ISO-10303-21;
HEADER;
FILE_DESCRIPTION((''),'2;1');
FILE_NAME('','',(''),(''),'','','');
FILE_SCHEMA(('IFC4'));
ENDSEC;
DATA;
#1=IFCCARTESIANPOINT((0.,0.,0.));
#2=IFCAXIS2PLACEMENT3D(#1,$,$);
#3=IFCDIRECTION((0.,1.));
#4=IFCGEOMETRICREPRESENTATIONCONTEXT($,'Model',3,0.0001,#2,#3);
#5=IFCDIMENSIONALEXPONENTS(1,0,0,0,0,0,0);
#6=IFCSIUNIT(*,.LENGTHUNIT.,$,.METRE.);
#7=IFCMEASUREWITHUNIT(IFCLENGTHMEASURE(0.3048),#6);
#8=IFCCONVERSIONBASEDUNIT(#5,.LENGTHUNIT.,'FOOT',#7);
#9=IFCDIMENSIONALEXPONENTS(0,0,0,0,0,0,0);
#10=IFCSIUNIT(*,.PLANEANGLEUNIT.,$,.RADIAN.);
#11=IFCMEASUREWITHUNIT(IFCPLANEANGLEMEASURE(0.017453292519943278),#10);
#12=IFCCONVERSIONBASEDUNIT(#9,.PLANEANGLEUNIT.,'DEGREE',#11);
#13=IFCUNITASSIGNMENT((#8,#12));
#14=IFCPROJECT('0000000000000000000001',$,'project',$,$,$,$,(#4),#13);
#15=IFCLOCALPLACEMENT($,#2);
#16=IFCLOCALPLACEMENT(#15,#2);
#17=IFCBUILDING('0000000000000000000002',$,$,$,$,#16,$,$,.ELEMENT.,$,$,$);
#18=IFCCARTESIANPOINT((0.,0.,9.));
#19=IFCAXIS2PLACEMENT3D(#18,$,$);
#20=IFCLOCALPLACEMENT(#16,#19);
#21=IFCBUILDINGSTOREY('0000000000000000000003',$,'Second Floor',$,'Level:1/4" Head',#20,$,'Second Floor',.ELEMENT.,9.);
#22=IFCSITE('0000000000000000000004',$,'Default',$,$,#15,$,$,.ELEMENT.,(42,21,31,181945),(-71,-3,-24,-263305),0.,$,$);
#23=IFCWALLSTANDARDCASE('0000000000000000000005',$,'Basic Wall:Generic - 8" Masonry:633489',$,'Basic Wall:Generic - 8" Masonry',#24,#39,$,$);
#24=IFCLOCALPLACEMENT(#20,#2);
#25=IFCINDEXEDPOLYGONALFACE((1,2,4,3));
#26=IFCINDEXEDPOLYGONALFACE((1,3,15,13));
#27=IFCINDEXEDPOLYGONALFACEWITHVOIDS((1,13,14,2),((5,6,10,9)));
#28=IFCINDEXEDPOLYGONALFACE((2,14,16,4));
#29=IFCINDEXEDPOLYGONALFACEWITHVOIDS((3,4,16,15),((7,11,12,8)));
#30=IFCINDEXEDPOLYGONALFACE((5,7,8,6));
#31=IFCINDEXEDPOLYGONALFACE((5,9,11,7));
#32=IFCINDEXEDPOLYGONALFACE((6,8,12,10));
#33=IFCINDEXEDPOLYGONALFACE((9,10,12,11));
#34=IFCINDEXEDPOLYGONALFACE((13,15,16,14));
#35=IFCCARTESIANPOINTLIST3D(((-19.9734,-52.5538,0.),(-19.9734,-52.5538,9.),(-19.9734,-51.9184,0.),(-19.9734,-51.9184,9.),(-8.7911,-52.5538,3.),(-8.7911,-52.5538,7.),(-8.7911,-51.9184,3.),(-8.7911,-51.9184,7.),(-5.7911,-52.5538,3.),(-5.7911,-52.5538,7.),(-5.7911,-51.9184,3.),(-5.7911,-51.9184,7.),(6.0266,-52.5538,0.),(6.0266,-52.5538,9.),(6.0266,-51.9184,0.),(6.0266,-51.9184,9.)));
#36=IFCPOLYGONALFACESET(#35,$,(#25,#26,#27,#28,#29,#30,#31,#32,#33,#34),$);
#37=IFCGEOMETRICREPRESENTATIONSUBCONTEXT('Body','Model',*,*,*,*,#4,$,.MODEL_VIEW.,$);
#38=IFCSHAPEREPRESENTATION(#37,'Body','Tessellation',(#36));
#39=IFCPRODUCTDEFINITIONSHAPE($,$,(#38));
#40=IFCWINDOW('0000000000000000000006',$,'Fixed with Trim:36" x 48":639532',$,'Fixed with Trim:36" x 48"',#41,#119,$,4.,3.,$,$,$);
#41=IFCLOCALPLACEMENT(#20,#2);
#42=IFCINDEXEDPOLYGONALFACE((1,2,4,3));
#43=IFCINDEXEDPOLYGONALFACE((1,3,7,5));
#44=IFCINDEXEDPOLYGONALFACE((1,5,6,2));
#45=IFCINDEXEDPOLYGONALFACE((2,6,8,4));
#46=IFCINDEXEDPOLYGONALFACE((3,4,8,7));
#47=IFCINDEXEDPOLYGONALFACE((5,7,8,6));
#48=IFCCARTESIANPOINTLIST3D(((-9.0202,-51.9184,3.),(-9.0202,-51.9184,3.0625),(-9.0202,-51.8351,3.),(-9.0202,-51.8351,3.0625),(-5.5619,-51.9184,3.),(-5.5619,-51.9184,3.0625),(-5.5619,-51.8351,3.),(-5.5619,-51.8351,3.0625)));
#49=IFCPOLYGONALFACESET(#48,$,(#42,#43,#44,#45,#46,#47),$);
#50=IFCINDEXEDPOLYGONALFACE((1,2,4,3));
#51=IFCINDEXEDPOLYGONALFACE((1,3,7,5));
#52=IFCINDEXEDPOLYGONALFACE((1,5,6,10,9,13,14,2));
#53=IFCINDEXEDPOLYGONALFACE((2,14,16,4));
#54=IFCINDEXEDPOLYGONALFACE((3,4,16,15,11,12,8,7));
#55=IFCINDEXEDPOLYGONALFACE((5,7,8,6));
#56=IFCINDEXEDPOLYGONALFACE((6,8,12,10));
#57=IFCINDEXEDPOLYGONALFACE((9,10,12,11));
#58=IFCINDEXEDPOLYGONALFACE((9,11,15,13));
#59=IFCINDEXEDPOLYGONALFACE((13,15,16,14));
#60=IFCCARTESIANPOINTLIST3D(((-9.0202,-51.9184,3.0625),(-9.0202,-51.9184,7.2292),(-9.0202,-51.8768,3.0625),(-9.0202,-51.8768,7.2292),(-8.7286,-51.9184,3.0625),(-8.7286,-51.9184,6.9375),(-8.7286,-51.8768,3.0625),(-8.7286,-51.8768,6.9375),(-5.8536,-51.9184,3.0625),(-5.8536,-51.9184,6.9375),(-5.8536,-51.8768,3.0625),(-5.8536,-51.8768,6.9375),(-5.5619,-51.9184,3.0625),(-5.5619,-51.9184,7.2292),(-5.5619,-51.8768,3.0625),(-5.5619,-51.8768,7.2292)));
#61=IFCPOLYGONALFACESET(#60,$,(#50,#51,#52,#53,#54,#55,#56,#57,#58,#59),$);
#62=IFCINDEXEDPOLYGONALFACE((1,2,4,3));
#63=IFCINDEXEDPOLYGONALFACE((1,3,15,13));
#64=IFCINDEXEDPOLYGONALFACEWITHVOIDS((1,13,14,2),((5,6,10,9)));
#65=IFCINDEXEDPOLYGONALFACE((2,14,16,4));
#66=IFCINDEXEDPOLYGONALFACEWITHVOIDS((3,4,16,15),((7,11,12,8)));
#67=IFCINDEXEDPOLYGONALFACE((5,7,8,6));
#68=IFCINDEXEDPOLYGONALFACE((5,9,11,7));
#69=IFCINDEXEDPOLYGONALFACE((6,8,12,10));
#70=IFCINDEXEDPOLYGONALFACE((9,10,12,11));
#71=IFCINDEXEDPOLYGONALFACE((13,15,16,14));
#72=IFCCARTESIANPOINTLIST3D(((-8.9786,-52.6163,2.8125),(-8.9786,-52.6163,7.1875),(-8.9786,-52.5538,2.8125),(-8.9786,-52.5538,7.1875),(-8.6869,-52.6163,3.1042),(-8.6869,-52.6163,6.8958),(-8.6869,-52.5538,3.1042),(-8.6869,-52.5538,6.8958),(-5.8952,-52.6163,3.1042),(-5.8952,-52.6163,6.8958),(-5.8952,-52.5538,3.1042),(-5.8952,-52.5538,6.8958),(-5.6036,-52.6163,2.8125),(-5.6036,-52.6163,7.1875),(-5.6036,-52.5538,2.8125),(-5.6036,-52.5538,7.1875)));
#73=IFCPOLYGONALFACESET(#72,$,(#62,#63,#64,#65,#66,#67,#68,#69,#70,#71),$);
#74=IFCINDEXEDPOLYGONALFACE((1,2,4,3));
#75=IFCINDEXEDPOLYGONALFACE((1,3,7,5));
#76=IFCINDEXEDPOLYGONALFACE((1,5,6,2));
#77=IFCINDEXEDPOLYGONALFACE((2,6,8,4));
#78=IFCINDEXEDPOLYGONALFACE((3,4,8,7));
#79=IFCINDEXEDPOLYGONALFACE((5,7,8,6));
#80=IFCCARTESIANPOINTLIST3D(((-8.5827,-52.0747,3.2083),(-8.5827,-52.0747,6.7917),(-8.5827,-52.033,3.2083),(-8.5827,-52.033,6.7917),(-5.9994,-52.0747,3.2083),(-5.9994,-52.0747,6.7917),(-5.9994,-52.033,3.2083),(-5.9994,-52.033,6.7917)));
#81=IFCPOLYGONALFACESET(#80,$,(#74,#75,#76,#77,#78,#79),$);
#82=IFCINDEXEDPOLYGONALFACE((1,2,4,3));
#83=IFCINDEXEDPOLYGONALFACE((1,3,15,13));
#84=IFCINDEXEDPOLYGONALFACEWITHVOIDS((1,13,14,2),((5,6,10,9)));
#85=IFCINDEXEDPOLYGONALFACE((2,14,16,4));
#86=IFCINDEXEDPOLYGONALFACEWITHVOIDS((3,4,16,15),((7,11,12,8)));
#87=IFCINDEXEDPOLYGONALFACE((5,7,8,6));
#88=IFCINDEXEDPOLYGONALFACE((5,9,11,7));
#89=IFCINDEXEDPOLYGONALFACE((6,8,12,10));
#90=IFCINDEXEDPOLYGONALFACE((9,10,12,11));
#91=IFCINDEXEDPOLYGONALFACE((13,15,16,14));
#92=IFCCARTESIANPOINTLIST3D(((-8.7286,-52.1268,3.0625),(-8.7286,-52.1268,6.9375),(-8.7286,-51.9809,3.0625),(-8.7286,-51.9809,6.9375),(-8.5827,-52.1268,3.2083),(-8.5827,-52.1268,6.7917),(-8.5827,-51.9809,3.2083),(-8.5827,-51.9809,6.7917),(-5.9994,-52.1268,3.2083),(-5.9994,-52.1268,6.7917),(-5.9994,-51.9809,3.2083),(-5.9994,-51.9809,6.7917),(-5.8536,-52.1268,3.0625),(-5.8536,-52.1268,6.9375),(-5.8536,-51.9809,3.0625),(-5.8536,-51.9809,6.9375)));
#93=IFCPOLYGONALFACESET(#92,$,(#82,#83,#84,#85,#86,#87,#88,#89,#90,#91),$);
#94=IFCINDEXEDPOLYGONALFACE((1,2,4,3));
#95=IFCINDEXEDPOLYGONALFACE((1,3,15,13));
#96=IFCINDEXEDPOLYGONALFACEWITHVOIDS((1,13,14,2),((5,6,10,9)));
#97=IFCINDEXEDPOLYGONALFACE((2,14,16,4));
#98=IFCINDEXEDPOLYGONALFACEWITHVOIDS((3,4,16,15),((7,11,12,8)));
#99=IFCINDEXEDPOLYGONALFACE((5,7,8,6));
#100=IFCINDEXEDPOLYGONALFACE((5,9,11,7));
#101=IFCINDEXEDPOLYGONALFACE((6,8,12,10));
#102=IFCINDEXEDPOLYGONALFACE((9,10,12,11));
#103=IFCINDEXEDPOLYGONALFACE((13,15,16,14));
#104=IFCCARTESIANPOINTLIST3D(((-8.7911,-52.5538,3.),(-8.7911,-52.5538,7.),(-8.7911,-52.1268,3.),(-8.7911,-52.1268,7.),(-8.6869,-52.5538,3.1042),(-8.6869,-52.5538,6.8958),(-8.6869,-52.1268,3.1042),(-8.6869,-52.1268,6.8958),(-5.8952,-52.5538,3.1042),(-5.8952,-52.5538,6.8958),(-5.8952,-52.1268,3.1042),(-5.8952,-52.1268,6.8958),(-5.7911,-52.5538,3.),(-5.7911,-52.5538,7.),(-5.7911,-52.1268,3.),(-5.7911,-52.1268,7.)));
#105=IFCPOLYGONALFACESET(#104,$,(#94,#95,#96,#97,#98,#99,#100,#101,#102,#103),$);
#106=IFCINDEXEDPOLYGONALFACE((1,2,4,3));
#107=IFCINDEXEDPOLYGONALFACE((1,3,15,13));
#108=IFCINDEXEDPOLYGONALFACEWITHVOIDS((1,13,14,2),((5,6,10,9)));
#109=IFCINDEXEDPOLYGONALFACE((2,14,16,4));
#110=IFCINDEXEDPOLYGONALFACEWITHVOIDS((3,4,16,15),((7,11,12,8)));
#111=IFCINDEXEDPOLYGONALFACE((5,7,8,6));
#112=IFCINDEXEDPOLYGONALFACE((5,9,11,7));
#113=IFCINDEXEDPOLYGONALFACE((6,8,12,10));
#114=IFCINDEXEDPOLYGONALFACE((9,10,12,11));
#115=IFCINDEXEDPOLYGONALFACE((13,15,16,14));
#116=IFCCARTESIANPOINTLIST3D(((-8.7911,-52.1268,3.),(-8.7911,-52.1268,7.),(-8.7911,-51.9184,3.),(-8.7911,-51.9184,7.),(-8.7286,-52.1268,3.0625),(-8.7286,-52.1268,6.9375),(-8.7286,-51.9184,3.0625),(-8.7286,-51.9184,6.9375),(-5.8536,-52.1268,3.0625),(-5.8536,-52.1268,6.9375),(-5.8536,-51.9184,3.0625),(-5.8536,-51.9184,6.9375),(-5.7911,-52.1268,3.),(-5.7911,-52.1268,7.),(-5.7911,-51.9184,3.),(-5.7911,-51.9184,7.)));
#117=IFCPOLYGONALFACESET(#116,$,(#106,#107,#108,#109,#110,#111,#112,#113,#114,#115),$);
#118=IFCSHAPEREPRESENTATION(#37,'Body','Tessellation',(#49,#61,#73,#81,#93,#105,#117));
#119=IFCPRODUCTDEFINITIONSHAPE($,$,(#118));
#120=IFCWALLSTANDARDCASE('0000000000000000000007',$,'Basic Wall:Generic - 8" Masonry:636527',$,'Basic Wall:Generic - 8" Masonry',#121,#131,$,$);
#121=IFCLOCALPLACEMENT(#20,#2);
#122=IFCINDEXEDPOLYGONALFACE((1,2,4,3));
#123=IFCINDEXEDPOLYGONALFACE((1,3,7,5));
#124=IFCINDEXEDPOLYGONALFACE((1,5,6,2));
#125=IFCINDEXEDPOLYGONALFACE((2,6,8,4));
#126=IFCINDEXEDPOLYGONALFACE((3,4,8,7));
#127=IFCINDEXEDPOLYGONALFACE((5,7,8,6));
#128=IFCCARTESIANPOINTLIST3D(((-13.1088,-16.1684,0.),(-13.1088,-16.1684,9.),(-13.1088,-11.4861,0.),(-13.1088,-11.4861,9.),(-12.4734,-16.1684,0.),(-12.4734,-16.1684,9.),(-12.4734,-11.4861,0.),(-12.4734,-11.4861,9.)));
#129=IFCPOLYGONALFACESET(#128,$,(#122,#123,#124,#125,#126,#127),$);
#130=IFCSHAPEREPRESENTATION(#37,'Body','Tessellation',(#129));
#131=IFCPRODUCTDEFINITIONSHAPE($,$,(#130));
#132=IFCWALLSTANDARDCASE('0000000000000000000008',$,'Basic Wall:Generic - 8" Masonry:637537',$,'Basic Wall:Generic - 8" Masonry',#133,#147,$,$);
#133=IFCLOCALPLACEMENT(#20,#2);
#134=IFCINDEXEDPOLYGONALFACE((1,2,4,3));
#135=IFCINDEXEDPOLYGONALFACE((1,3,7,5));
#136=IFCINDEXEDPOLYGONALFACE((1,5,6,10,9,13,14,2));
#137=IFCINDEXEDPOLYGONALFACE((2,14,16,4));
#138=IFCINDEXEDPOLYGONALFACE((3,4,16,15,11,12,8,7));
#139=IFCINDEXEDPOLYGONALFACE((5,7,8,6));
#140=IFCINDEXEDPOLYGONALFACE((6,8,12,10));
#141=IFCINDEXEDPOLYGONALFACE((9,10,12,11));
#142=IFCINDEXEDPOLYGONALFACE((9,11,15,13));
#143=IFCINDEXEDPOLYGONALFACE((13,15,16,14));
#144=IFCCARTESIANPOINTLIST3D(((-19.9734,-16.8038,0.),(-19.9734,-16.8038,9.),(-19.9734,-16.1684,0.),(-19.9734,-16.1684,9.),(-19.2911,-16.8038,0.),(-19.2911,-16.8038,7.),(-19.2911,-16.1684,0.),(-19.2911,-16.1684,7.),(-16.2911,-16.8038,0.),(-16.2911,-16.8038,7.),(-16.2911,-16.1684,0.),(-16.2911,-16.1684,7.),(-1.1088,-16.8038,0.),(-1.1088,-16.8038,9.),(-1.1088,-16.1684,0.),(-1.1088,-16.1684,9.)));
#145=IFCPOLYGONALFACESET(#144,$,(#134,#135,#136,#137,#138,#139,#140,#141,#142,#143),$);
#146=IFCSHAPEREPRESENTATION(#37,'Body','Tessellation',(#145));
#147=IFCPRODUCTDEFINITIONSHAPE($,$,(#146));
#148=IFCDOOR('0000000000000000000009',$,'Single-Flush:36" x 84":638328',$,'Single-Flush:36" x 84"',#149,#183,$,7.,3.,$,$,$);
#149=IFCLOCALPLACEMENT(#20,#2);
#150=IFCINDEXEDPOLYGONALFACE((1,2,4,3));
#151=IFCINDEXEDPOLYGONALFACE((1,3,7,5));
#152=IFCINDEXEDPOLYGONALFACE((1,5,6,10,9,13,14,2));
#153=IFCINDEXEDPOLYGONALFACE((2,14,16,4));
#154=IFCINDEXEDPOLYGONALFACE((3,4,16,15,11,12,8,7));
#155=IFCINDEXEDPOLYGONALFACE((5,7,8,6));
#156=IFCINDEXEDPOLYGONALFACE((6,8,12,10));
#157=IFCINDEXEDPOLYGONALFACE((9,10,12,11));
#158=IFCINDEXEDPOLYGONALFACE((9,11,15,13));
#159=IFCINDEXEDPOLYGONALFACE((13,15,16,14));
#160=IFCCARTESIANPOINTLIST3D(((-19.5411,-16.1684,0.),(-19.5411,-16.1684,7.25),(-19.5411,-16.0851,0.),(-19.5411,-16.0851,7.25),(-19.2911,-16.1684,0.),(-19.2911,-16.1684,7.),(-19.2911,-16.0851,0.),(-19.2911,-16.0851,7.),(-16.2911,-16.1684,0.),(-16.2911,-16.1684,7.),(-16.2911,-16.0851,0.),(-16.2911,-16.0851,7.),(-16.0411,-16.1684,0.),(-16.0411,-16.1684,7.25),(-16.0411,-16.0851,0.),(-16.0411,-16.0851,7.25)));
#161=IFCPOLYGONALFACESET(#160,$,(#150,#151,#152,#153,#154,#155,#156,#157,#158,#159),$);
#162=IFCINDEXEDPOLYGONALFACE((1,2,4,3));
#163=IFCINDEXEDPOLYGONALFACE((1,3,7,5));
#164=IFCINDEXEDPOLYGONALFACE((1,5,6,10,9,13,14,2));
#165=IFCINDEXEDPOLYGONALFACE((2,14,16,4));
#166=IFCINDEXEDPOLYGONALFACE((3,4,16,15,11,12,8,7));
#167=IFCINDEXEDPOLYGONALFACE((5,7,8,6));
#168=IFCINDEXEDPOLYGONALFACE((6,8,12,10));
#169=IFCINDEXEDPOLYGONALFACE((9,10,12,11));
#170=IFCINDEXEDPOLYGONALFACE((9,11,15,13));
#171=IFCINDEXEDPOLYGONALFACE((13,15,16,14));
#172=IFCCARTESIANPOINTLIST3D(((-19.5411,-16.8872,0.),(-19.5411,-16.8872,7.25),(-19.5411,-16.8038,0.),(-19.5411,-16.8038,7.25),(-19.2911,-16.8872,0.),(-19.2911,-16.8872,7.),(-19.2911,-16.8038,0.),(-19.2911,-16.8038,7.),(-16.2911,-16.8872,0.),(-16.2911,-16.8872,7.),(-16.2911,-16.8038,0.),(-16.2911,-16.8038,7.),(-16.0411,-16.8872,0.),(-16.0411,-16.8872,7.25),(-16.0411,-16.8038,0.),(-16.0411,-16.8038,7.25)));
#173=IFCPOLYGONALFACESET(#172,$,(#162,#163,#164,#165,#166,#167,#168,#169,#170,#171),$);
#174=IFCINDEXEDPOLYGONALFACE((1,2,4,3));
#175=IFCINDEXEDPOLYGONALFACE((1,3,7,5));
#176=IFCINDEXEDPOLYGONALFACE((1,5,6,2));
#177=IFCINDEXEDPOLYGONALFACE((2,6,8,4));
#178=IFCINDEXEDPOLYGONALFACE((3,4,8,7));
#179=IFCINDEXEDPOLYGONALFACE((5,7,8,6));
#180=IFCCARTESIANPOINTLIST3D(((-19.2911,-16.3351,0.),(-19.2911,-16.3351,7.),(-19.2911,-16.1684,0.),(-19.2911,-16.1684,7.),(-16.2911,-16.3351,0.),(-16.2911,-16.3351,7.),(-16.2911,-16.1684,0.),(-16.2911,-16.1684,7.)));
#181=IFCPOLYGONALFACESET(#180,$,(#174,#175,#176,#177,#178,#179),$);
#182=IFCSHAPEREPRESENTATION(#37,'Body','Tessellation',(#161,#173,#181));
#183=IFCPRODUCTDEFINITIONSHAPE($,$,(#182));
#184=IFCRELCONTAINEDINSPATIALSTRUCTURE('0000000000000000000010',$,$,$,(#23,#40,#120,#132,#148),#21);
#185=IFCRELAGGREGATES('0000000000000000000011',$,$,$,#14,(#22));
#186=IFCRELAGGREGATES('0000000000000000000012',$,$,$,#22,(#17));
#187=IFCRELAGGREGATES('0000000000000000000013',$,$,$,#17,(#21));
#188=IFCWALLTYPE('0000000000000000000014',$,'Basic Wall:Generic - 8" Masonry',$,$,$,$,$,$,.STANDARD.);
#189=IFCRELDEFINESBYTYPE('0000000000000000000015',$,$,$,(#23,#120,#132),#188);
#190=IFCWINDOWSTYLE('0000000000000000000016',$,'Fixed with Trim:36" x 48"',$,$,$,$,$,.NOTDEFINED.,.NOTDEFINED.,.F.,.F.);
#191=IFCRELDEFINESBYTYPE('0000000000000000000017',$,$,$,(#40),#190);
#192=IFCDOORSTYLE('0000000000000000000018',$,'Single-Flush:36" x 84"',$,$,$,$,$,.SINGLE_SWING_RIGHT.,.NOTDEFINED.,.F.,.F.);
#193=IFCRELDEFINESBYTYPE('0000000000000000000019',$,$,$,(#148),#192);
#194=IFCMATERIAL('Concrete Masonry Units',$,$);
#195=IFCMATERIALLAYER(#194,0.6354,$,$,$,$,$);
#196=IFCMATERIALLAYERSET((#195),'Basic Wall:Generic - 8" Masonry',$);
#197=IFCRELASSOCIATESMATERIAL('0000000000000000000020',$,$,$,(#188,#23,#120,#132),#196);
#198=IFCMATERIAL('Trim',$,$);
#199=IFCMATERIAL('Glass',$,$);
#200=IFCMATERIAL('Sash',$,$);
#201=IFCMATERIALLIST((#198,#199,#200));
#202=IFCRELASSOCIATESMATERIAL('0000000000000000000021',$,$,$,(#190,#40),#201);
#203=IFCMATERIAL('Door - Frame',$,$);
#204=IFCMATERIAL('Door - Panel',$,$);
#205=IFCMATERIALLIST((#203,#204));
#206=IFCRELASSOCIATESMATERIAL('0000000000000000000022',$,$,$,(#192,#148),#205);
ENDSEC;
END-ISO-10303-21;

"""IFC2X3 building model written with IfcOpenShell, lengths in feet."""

from ifc_helpers import new_model, entity, si_unit, converted_unit, direction, frame, frame_2d, origin, origin_2d_with_axis, place, context, subcontext, project, spatial, polyline, rectangle, outline, extrude, source, transform, mapped, material, material_list, layer, layer_set, layer_usage, type_object, type_shapes, element, fill, save


model = new_model("IFC2X3")

# Units and contexts
model_context = context("Model", 3, precision=0.0001, world=origin(), true_north=direction((0.0, 1.0)))
body_context = subcontext(model_context, "Body", "Model", "MODEL_VIEW")
ifc_project = project(units=[converted_unit("LENGTHUNIT", "FOOT", entity("IfcLengthMeasure", 0.3048), si_unit("LENGTHUNIT", "METRE"), dimensions=[1, 0, 0, 0, 0, 0, 0]), converted_unit("PLANEANGLEUNIT", "DEGREE", entity("IfcPlaneAngleMeasure", 0.017453292519943278), si_unit("PLANEANGLEUNIT", "RADIAN"), dimensions=[0, 0, 0, 0, 0, 0, 0])], contexts=[model_context])

# Site, building, storey
site_placement = place(None, origin())
site = spatial("IfcSite", under=ifc_project, at=site_placement, Name="Default", CompositionType="ELEMENT", RefLatitude=(42, 21, 31, 181945), RefLongitude=(-71, -3, -24, -263305), RefElevation=0.0)
building_placement = place(site_placement, origin())
building = spatial("IfcBuilding", under=site, at=building_placement, CompositionType="ELEMENT")
storey_placement = place(building_placement, frame((0.0, 0.0, 9.0)))
storey = spatial("IfcBuildingStorey", under=building, at=storey_placement, Name="Second Floor", ObjectType="Level:1/4\" Head", LongName="Second Floor", CompositionType="ELEMENT", Elevation=9.0)

# Shared definitions
ifc_material_1 = material(Name="Concrete Masonry Units")
ifc_layer = layer(ifc_material_1, 0.6354)
ifc_layer_set = layer_set([ifc_layer], Name="Basic Wall:Generic - 8\" Masonry")
wall_type = type_object("IfcWallType", Name="Basic Wall:Generic - 8\" Masonry", PredefinedType="STANDARD", material=ifc_layer_set)
ifc_material_2 = material(Name="Trim")
ifc_material_3 = material(Name="Glass")
ifc_material_4 = material(Name="Sash")
ifc_material_list_1 = material_list([ifc_material_2, ifc_material_3, ifc_material_4])
window_style = type_object("IfcWindowStyle", Name="Fixed with Trim:36\" x 48\"", ConstructionType="NOTDEFINED", OperationType="NOTDEFINED", ParameterTakesPrecedence=False, Sizeable=False, material=ifc_material_list_1)
shared_shape_1 = source(origin(), body_context, "Body", "SweptSolid", [
    extrude(rectangle(XDim=0.0833, YDim=3.4583, at=origin_2d_with_axis()), frame((1.5, 0.6771, 0.0), z_axis=(0.0, 0.0, 1.0), x_axis=(0.0, -1.0, 0.0)), (0.0, 0.0, 1.0), 0.0625),
    extrude(outline(polyline([(-1.8646, 1.4375), (2.0104, 1.4375), (2.0104, 1.7292), (-2.1562, 1.7292), (-2.1562, -1.7292), (2.0104, -1.7292), (2.0104, -1.4375), (-1.8646, -1.4375), (-1.8646, 1.4375)])), frame((1.5, 0.6354, 2.0729), z_axis=(0.0, 1.0, 0.0), x_axis=(0.0, 0.0, -1.0)), (0.0, 0.0, 1.0), 0.0417),
    extrude(outline(polyline([(-2.1875, -1.6875), (2.1875, -1.6875), (2.1875, 1.6875), (-2.1875, 1.6875), (-2.1875, -1.6875)]), holes=[polyline([(-1.8958, -1.3958), (-1.8958, 1.3958), (1.8958, 1.3958), (1.8958, -1.3958), (-1.8958, -1.3958)])]), frame((1.5, -0.0625, 2.0), z_axis=(0.0, 1.0, 0.0), x_axis=(0.0, 0.0, -1.0)), (0.0, 0.0, 1.0), 0.0625),
    extrude(rectangle(XDim=0.0417, YDim=2.5833, at=frame_2d((0.0, 0.0), x_axis=(1.0, 0.0))), frame((1.5, 0.5, 0.2083), z_axis=(0.0, 0.0, 1.0), x_axis=(0.0, 1.0, 0.0)), (0.0, 0.0, 1.0), 3.5833),
    extrude(outline(polyline([(-1.4375, -1.9375), (1.4375, -1.9375), (1.4375, 1.9375), (-1.4375, 1.9375), (-1.4375, -1.9375)]), holes=[polyline([(-1.2917, -1.7917), (-1.2917, 1.7917), (1.2917, 1.7917), (1.2917, -1.7917), (-1.2917, -1.7917)])]), frame((1.5, 0.4271, 2.0), z_axis=(0.0, 1.0, 0.0), x_axis=(1.0, 0.0, 0.0)), (0.0, 0.0, 1.0), 0.1458),
    extrude(outline(polyline([(-1.5, -2.0), (1.5, -2.0), (1.5, 2.0), (-1.5, 2.0), (-1.5, -2.0)]), holes=[polyline([(-1.3958, -1.8958), (-1.3958, 1.8958), (1.3958, 1.8958), (1.3958, -1.8958), (-1.3958, -1.8958)])]), frame((1.5, 0.0, 2.0), z_axis=(0.0, 1.0, 0.0), x_axis=(1.0, 0.0, 0.0)), (0.0, 0.0, 1.0), 0.4271),
    extrude(outline(polyline([(-2.0, -1.5), (2.0, -1.5), (2.0, 1.5), (-2.0, 1.5), (-2.0, -1.5)]), holes=[polyline([(-1.9375, -1.4375), (-1.9375, 1.4375), (1.9375, 1.4375), (1.9375, -1.4375), (-1.9375, -1.4375)])]), frame((1.5, 0.4271, 2.0), z_axis=(0.0, 1.0, 0.0), x_axis=(0.0, 0.0, -1.0)), (0.0, 0.0, 1.0), 0.2083),
])
type_shapes(window_style, [shared_shape_1])

# Wall, opening, window
ifc_layer_usage_1 = layer_usage(ifc_layer_set, "AXIS2", "NEGATIVE", 0.3177)
wall_1_placement = place(storey_placement, frame((-19.9734, -52.2361, 0.0)))
wall_1 = element("IfcWallStandardCase", 1, at=wall_1_placement, inside=storey, type_object=wall_type, material=ifc_layer_usage_1, Name="Basic Wall:Generic - 8\" Masonry:633489", ObjectType="Basic Wall:Generic - 8\" Masonry", context=body_context, shape_type="SweptSolid", body=[
    extrude(rectangle(XDim=26.0, YDim=0.6354, at=frame_2d((13.0, 0.0), x_axis=(-1.0, 0.0))), origin(), (0.0, 0.0, 1.0), 9.0),
])
opening_1_placement = place(wall_1_placement, frame((11.1823, -0.3177, 3.0)))
opening_1 = element("IfcOpeningElement", 2, at=opening_1_placement, cuts=wall_1, ObjectType="Opening", context=body_context, shape_type="SweptSolid", body=[
    extrude(rectangle(XDim=4.0, YDim=3.0, at=frame_2d((2.0, 1.5), x_axis=(-1.0, 0.0))), frame((0.0, 0.0, 0.0), z_axis=(0.0, 1.0, 0.0), x_axis=(0.0, 0.0, 1.0)), (0.0, 0.0, 1.0), 0.6354),
])
window_1_placement = place(opening_1_placement, origin())
window_1 = element("IfcWindow", 3, at=window_1_placement, inside=storey, type_object=window_style, material=ifc_material_list_1, Name="Fixed with Trim:36\" x 48\":639532", ObjectType="Fixed with Trim:36\" x 48\"", OverallHeight=4.0, OverallWidth=3.0, context=body_context, shape_type="MappedRepresentation", body=[
    mapped(shared_shape_1, transform((0.0, 0.0, 0.0), scale=1.0)),
])
fill(opening_1, window_1)

# Wall
ifc_layer_usage_2 = layer_usage(ifc_layer_set, "AXIS2", "NEGATIVE", 0.3177)
wall_2_placement = place(storey_placement, frame((-12.7911, -16.1684, 0.0), z_axis=(0.0, 0.0, 1.0), x_axis=(0.0, 1.0, 0.0)))
element("IfcWallStandardCase", 4, at=wall_2_placement, inside=storey, type_object=wall_type, material=ifc_layer_usage_2, Name="Basic Wall:Generic - 8\" Masonry:636527", ObjectType="Basic Wall:Generic - 8\" Masonry", context=body_context, shape_type="SweptSolid", body=[
    extrude(rectangle(XDim=4.6823, YDim=0.6354, at=frame_2d((2.3411, 0.0), x_axis=(-1.0, 0.0))), origin(), (0.0, 0.0, 1.0), 9.0),
])

# Wall, opening, door
ifc_layer_usage_3 = layer_usage(ifc_layer_set, "AXIS2", "NEGATIVE", 0.3177)
wall_3_placement = place(storey_placement, frame((-1.1088, -16.4861, 0.0), z_axis=(0.0, 0.0, 1.0), x_axis=(-1.0, 0.0, 0.0)))
wall_3 = element("IfcWallStandardCase", 5, at=wall_3_placement, inside=storey, type_object=wall_type, material=ifc_layer_usage_3, Name="Basic Wall:Generic - 8\" Masonry:637537", ObjectType="Basic Wall:Generic - 8\" Masonry", context=body_context, shape_type="SweptSolid", body=[
    extrude(rectangle(XDim=18.8646, YDim=0.6354, at=frame_2d((9.4323, 0.0), x_axis=(1.0, 0.0))), origin(), (0.0, 0.0, 1.0), 9.0),
])
opening_2_placement = place(wall_3_placement, frame((18.1823, 0.3177, 0.0)))
opening_2 = element("IfcOpeningElement", 6, at=opening_2_placement, cuts=wall_3, ObjectType="Opening", context=body_context, shape_type="SweptSolid", body=[
    extrude(rectangle(XDim=3.0, YDim=7.0, at=frame_2d((3.5, 1.5), x_axis=(0.0, 1.0))), frame((0.0, 0.0, 0.0), z_axis=(0.0, -1.0, 0.0), x_axis=(0.0, 0.0, 1.0)), (0.0, 0.0, 1.0), 0.6354),
])
ifc_material_5 = material(Name="Door - Frame")
ifc_material_6 = material(Name="Door - Panel")
ifc_material_list_2 = material_list([ifc_material_5, ifc_material_6])
door_style = type_object("IfcDoorStyle", Name="Single-Flush:36\" x 84\"", ConstructionType="NOTDEFINED", OperationType="SINGLE_SWING_RIGHT", ParameterTakesPrecedence=False, Sizeable=False, material=ifc_material_list_2)
shared_shape_2 = source(origin(), body_context, "Body", "SweptSolid", [
    extrude(outline(polyline([(-1.75, -3.6875), (1.75, -3.6875), (1.75, 3.5625), (1.5, 3.5625), (1.5, -3.4375), (-1.5, -3.4375), (-1.5, 3.5625), (-1.75, 3.5625), (-1.75, -3.6875)])), frame((1.5, 0.6354, 3.5625), z_axis=(0.0, 1.0, 0.0), x_axis=(1.0, 0.0, 0.0)), (0.0, 0.0, 1.0), 0.0833),
    extrude(outline(polyline([(-3.6875, -1.75), (3.5625, -1.75), (3.5625, -1.5), (-3.4375, -1.5), (-3.4375, 1.5), (3.5625, 1.5), (3.5625, 1.75), (-3.6875, 1.75), (-3.6875, -1.75)])), frame((1.5, -0.0833, 3.5625), z_axis=(0.0, 1.0, 0.0), x_axis=(0.0, 0.0, -1.0)), (0.0, 0.0, 1.0), 0.0833),
    extrude(rectangle(XDim=0.1667, YDim=3.0, at=frame_2d((0.0, 0.0), x_axis=(1.0, 0.0))), frame((1.5, 0.5521, 0.0), z_axis=(0.0, 0.0, 1.0), x_axis=(0.0, 1.0, 0.0)), (0.0, 0.0, 1.0), 7.0),
])
type_shapes(door_style, [shared_shape_2])
door_placement = place(opening_2_placement, frame((0.0, 0.0, 0.0), z_axis=(0.0, 0.0, 1.0), x_axis=(-1.0, 0.0, 0.0)))
door = element("IfcDoor", 7, at=door_placement, inside=storey, type_object=door_style, material=ifc_material_list_2, Name="Single-Flush:36\" x 84\":638328", ObjectType="Single-Flush:36\" x 84\"", OverallHeight=7.0, OverallWidth=3.0, context=body_context, shape_type="MappedRepresentation", body=[
    mapped(shared_shape_2, transform((0.0, 0.0, 0.0), scale=1.0)),
])
fill(opening_2, door)

save(model, "model.ifc")
